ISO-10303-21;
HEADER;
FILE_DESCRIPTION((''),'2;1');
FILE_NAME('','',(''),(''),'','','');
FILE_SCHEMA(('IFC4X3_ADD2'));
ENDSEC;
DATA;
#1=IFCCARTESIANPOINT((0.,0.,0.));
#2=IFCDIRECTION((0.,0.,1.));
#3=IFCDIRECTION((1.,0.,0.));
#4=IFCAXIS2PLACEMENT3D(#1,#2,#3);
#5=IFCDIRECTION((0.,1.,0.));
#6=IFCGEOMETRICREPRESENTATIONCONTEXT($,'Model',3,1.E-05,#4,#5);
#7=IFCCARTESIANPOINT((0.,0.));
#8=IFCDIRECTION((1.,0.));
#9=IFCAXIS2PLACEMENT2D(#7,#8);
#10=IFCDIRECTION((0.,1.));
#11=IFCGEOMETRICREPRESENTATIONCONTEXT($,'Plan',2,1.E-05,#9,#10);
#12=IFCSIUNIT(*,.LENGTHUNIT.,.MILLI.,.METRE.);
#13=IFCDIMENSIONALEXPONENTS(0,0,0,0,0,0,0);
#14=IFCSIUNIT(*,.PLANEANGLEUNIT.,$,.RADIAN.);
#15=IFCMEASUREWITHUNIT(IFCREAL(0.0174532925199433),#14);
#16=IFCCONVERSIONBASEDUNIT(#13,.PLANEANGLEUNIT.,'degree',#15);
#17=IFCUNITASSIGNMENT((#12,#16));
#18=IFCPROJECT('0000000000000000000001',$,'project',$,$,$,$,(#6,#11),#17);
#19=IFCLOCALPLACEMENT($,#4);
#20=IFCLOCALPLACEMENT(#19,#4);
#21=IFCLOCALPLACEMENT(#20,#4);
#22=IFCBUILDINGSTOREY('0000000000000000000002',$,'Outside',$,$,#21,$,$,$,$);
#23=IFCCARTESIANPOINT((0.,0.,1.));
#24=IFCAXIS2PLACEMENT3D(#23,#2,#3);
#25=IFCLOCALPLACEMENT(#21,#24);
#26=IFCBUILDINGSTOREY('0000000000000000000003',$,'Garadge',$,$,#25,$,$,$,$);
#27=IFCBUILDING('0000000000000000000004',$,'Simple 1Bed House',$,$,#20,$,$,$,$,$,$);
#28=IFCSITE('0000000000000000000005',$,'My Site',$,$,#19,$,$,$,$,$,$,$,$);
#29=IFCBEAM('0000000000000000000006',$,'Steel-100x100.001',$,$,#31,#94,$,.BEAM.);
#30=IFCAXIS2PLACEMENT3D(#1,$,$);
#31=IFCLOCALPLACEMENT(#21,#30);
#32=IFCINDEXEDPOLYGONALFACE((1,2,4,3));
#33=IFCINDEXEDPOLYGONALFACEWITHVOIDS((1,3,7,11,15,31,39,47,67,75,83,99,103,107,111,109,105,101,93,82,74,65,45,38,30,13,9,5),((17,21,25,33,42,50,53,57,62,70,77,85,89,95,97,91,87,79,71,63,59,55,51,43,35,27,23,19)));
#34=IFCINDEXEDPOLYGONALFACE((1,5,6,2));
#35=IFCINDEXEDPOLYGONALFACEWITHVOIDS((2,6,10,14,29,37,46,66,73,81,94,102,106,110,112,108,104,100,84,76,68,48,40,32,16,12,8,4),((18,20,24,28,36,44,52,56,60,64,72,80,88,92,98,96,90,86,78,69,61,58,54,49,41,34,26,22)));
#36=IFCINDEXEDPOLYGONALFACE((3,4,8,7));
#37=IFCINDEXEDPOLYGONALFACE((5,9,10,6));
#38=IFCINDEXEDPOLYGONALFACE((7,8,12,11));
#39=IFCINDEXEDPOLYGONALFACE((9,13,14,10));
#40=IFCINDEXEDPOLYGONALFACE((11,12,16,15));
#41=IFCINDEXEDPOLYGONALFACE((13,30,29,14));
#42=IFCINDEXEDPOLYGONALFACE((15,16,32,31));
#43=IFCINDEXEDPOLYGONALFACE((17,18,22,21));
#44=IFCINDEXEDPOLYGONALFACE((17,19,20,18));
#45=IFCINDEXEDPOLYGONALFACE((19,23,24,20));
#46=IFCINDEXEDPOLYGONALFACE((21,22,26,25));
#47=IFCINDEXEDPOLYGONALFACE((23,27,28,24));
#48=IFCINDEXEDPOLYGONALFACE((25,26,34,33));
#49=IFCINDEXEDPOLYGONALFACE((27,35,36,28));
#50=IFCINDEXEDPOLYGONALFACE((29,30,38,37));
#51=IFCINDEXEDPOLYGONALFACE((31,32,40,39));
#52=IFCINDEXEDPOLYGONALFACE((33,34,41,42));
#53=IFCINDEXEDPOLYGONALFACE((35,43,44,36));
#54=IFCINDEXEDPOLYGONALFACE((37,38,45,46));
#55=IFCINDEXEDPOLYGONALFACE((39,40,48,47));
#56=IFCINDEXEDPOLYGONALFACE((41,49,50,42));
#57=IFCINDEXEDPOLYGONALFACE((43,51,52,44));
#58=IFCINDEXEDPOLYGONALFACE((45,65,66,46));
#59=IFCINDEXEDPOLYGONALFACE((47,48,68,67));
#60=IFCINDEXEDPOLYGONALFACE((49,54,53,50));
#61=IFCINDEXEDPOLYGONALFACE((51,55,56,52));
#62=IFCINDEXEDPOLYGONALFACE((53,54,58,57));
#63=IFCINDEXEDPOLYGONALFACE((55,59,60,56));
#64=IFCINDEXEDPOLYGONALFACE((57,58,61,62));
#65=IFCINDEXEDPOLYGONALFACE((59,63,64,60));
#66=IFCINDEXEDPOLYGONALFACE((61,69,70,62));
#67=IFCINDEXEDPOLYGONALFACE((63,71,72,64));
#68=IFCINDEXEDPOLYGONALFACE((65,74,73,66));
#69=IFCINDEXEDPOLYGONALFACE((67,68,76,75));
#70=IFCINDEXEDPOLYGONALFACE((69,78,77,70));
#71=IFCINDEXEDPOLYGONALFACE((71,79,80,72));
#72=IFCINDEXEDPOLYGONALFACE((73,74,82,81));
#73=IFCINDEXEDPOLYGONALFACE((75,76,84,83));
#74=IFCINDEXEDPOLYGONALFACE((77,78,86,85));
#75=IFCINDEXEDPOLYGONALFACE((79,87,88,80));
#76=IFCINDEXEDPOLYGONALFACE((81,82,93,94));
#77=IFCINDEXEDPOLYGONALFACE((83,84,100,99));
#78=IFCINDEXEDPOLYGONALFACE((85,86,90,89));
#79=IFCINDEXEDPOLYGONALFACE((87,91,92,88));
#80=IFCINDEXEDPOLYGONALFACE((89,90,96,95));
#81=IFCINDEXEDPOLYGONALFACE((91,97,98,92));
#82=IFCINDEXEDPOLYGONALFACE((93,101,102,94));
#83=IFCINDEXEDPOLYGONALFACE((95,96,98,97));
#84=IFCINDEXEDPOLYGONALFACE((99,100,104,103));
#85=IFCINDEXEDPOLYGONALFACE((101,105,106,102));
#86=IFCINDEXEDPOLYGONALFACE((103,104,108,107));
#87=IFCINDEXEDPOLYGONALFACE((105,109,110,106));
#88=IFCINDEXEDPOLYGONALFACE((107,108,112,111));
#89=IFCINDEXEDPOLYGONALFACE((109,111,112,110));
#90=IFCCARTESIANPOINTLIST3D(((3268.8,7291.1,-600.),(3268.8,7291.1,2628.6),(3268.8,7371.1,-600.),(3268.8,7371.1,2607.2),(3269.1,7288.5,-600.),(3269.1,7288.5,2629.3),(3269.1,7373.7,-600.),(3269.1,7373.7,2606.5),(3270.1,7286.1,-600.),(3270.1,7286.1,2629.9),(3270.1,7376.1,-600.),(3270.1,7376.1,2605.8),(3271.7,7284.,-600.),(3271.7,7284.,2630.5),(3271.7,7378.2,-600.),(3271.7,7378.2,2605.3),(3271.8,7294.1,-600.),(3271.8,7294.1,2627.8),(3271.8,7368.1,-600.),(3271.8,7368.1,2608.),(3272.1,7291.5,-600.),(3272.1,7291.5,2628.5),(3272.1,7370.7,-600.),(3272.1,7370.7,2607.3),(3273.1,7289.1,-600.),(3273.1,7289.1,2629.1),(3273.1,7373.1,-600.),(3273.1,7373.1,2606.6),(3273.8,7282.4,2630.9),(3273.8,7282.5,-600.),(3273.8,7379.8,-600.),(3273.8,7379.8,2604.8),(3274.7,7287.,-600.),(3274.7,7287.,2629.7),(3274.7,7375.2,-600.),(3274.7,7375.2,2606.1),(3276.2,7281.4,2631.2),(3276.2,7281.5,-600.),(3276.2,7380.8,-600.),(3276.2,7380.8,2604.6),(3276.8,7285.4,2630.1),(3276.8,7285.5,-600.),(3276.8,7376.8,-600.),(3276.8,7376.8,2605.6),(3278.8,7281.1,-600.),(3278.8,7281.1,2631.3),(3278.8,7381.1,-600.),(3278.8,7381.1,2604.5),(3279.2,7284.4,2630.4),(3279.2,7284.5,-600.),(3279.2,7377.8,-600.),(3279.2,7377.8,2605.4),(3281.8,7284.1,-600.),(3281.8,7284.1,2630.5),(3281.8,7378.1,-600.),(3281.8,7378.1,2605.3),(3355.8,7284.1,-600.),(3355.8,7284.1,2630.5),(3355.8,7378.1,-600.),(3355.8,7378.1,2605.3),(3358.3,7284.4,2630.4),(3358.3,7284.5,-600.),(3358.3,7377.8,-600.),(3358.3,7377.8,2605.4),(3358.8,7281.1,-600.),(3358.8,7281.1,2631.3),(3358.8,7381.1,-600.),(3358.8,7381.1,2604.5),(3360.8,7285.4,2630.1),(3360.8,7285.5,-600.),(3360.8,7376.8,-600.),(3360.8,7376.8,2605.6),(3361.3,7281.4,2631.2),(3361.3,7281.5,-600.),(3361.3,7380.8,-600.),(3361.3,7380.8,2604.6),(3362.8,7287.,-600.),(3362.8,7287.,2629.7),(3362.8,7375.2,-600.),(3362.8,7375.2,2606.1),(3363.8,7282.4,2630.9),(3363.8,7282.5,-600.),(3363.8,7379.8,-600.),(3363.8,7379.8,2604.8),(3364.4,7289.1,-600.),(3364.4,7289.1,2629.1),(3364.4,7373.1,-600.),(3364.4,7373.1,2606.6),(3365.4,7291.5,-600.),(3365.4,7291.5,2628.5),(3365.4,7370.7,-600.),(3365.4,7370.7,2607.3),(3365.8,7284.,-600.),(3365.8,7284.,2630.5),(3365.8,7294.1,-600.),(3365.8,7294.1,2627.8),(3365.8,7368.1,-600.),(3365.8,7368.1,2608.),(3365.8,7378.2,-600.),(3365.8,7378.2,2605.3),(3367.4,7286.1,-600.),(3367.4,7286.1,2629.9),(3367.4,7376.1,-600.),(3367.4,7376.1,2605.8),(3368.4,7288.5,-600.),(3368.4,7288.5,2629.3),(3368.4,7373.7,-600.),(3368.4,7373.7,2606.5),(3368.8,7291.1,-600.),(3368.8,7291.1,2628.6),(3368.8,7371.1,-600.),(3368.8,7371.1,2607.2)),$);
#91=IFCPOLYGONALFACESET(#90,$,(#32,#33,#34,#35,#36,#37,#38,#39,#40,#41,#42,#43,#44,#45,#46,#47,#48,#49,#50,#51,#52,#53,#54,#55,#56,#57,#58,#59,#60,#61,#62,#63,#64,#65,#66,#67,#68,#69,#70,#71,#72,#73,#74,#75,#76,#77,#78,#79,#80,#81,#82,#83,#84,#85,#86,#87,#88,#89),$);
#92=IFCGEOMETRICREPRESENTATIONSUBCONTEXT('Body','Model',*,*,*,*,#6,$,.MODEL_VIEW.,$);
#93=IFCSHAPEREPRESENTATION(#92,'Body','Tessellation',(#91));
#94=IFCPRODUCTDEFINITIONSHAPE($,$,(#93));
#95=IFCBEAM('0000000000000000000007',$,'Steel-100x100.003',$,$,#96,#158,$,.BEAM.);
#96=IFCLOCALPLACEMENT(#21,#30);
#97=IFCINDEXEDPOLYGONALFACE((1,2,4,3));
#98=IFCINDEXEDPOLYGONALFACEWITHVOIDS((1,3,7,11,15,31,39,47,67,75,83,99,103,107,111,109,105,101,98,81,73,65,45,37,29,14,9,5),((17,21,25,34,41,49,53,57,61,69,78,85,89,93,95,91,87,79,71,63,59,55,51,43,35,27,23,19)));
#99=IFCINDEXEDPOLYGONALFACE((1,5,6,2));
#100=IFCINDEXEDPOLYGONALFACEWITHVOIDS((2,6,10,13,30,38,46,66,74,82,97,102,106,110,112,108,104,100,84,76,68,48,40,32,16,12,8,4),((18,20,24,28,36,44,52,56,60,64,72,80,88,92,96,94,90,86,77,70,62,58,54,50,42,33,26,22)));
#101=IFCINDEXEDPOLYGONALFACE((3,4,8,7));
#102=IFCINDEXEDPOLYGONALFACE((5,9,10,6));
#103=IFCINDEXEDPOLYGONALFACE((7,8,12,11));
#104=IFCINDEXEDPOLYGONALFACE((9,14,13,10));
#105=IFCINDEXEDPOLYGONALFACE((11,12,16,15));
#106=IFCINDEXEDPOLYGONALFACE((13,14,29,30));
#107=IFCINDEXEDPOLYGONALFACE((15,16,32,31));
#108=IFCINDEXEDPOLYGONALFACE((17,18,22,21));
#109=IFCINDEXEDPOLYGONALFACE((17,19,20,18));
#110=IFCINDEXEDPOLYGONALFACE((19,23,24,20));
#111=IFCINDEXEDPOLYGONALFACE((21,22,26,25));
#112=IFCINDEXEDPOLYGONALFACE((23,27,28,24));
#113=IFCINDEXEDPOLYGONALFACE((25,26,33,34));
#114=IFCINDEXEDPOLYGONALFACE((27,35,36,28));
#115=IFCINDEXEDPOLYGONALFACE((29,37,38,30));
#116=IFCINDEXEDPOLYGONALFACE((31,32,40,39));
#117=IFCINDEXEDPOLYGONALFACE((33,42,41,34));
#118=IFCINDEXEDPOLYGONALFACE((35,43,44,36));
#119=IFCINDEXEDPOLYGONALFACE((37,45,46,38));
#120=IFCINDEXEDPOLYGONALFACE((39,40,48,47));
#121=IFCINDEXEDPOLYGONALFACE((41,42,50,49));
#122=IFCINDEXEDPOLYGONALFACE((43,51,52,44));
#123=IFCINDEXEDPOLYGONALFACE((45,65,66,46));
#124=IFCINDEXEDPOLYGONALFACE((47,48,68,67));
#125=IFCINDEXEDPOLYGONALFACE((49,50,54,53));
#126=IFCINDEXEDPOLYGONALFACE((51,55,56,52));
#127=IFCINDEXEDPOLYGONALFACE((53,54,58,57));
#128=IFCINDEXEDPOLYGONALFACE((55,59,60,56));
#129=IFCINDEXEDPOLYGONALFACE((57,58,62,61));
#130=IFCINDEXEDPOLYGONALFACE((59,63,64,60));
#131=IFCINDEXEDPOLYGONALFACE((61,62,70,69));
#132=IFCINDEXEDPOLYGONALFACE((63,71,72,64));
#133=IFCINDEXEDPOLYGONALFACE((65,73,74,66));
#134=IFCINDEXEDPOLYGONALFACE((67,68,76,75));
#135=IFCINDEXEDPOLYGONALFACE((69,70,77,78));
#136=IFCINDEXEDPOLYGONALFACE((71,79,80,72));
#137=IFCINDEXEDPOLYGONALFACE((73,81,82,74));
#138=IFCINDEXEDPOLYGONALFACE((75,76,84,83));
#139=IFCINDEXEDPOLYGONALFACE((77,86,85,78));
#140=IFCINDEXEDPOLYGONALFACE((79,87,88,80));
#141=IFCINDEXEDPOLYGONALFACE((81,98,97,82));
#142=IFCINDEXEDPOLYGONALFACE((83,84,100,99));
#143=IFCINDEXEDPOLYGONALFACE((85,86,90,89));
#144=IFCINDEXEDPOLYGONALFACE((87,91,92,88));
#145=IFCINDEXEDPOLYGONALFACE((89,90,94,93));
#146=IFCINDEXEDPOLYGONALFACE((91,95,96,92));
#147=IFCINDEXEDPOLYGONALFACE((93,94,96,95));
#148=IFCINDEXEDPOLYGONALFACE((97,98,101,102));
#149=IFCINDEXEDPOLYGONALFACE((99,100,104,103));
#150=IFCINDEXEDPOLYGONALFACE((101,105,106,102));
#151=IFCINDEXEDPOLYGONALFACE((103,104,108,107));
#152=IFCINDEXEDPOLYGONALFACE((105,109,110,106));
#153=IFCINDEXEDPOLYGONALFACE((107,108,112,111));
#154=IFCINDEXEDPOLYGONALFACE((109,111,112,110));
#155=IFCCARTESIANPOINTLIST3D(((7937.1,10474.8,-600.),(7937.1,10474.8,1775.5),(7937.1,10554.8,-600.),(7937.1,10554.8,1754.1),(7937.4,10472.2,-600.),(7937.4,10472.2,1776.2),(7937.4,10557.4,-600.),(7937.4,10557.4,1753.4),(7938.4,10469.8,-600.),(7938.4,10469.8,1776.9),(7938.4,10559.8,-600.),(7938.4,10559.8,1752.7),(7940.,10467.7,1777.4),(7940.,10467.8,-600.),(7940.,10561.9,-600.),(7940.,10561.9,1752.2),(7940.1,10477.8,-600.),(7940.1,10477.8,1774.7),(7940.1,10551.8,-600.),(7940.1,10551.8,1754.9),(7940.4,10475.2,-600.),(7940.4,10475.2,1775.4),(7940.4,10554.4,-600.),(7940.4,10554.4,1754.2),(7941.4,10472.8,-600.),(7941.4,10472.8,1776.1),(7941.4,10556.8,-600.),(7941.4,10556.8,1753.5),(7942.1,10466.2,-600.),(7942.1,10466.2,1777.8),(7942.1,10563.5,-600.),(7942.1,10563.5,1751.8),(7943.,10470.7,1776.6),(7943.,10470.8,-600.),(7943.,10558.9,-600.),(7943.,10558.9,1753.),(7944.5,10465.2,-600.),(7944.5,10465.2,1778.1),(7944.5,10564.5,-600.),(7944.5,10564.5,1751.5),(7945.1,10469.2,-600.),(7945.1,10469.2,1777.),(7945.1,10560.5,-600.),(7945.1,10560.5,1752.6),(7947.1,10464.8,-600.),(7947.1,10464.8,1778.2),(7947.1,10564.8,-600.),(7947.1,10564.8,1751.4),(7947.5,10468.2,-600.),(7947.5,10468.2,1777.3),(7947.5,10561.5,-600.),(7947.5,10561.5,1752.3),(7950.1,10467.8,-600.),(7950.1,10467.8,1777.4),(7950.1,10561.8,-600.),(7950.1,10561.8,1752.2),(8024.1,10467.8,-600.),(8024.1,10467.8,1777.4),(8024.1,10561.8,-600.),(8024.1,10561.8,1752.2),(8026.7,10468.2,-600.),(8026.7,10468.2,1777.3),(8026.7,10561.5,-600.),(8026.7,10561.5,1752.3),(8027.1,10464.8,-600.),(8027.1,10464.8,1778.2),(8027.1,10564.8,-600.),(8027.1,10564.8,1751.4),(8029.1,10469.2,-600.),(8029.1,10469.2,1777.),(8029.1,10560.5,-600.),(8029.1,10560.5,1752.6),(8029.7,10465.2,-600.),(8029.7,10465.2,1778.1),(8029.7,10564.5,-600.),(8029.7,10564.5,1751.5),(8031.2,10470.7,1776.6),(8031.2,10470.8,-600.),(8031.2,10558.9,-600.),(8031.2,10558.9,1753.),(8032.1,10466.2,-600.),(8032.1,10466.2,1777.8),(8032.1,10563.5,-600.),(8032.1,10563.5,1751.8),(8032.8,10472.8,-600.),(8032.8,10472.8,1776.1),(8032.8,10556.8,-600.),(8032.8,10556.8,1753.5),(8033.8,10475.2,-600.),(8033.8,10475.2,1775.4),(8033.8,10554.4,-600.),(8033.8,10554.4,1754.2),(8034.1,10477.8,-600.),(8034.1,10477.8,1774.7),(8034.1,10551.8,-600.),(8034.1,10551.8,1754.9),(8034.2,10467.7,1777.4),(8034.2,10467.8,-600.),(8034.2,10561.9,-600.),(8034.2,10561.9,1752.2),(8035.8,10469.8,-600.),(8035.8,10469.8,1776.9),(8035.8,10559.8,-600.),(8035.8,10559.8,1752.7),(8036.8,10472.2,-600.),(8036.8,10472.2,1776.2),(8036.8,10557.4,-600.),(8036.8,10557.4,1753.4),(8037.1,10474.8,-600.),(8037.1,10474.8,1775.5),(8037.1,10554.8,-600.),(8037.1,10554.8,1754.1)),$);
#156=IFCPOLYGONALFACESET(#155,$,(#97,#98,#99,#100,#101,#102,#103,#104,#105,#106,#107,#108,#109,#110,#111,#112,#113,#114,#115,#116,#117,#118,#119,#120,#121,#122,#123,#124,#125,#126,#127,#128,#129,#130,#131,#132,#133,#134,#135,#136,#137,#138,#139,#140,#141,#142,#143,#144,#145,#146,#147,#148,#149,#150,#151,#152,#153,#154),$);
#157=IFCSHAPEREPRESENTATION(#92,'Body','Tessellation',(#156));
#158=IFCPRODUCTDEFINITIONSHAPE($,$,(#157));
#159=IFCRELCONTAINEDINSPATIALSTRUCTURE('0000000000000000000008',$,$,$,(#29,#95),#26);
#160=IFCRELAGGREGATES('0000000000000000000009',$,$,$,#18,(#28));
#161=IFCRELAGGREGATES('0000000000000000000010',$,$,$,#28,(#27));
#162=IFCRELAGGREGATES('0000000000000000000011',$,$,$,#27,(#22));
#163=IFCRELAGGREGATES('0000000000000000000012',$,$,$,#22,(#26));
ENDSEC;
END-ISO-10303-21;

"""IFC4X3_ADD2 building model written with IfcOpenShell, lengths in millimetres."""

from ifc_helpers import new_model, entity, si_unit, converted_unit, direction, frame, origin_with_axes, origin_2d_with_axis, place, context, subcontext, project, spatial, hollow_rectangle, extrude, clip, halfspace, element, save


model = new_model("IFC4X3_ADD2")

# Units and contexts
model_context = context("Model", 3, precision=1e-05, world=origin_with_axes(), true_north=direction((0.0, 1.0, 0.0)))
plan_context = context("Plan", 2, precision=1e-05, world=origin_2d_with_axis(), true_north=direction((0.0, 1.0)))
body_context = subcontext(model_context, "Body", "Model", "MODEL_VIEW")
ifc_project = project(units=[si_unit("LENGTHUNIT", "METRE", prefix="MILLI"), converted_unit("PLANEANGLEUNIT", "degree", entity("IfcReal", 0.0174532925199433), si_unit("PLANEANGLEUNIT", "RADIAN"), dimensions=[0, 0, 0, 0, 0, 0, 0])], contexts=[model_context, plan_context])

# Site, building, storeys
site_placement = place(None, origin_with_axes())
site = spatial("IfcSite", under=ifc_project, at=site_placement, Name="My Site")
building_placement = place(site_placement, origin_with_axes())
building = spatial("IfcBuilding", under=site, at=building_placement, Name="Simple 1Bed House")
storey_1_placement = place(building_placement, origin_with_axes())
storey_1 = spatial("IfcBuildingStorey", under=building, at=storey_1_placement, Name="Outside")
storey_2_placement = place(storey_1_placement, frame((0.0, 0.0, 1.0), z_axis=(0.0, 0.0, 1.0), x_axis=(1.0, 0.0, 0.0)))
storey_2 = spatial("IfcBuildingStorey", under=storey_1, at=storey_2_placement, Name="Garadge")

# Beams
beam_1_placement = place(storey_2_placement, frame((3318.8, 7331.1, -601.0), z_axis=(0.0, -0.000003, 1.0), x_axis=(-1.0, 0.0, 0.0)))
element("IfcBeam", 1, at=beam_1_placement, inside=storey_2, Name="Steel-100x100.001", PredefinedType="BEAM", context=body_context, shape_type="Clipping", body=[
    clip(extrude(hollow_rectangle(XDim=100.0, YDim=100.0, WallThickness=3.0, InnerFilletRadius=10.0, OuterFilletRadius=10.0, kind="CURVE"), origin_with_axes(), (0.0, 0.0, 1.0), 3317.9), halfspace(frame((0.0, -3520.4, 2274.6), z_axis=(0.0, -0.258822, 0.965925), x_axis=(-1.0, -0.000001, 0.0)), False)),
])
beam_2_placement = place(storey_2_placement, frame((7987.1, 10514.8, -601.0), z_axis=(0.0, -0.000003, 1.0), x_axis=(-1.0, 0.0, 0.0)))
element("IfcBeam", 2, at=beam_2_placement, inside=storey_2, Name="Steel-100x100.003", PredefinedType="BEAM", context=body_context, shape_type="Clipping", body=[
    clip(extrude(hollow_rectangle(XDim=100.0, YDim=100.0, WallThickness=3.0, InnerFilletRadius=10.0, OuterFilletRadius=10.0, kind="CURVE"), origin_with_axes(), (0.0, 0.0, 1.0), 2464.8), halfspace(frame((0.0, -336.7, 2274.6), z_axis=(0.0, -0.258822, 0.965925), x_axis=(-1.0, -0.000001, 0.0)), False)),
])

save(model, "model.ifc")
